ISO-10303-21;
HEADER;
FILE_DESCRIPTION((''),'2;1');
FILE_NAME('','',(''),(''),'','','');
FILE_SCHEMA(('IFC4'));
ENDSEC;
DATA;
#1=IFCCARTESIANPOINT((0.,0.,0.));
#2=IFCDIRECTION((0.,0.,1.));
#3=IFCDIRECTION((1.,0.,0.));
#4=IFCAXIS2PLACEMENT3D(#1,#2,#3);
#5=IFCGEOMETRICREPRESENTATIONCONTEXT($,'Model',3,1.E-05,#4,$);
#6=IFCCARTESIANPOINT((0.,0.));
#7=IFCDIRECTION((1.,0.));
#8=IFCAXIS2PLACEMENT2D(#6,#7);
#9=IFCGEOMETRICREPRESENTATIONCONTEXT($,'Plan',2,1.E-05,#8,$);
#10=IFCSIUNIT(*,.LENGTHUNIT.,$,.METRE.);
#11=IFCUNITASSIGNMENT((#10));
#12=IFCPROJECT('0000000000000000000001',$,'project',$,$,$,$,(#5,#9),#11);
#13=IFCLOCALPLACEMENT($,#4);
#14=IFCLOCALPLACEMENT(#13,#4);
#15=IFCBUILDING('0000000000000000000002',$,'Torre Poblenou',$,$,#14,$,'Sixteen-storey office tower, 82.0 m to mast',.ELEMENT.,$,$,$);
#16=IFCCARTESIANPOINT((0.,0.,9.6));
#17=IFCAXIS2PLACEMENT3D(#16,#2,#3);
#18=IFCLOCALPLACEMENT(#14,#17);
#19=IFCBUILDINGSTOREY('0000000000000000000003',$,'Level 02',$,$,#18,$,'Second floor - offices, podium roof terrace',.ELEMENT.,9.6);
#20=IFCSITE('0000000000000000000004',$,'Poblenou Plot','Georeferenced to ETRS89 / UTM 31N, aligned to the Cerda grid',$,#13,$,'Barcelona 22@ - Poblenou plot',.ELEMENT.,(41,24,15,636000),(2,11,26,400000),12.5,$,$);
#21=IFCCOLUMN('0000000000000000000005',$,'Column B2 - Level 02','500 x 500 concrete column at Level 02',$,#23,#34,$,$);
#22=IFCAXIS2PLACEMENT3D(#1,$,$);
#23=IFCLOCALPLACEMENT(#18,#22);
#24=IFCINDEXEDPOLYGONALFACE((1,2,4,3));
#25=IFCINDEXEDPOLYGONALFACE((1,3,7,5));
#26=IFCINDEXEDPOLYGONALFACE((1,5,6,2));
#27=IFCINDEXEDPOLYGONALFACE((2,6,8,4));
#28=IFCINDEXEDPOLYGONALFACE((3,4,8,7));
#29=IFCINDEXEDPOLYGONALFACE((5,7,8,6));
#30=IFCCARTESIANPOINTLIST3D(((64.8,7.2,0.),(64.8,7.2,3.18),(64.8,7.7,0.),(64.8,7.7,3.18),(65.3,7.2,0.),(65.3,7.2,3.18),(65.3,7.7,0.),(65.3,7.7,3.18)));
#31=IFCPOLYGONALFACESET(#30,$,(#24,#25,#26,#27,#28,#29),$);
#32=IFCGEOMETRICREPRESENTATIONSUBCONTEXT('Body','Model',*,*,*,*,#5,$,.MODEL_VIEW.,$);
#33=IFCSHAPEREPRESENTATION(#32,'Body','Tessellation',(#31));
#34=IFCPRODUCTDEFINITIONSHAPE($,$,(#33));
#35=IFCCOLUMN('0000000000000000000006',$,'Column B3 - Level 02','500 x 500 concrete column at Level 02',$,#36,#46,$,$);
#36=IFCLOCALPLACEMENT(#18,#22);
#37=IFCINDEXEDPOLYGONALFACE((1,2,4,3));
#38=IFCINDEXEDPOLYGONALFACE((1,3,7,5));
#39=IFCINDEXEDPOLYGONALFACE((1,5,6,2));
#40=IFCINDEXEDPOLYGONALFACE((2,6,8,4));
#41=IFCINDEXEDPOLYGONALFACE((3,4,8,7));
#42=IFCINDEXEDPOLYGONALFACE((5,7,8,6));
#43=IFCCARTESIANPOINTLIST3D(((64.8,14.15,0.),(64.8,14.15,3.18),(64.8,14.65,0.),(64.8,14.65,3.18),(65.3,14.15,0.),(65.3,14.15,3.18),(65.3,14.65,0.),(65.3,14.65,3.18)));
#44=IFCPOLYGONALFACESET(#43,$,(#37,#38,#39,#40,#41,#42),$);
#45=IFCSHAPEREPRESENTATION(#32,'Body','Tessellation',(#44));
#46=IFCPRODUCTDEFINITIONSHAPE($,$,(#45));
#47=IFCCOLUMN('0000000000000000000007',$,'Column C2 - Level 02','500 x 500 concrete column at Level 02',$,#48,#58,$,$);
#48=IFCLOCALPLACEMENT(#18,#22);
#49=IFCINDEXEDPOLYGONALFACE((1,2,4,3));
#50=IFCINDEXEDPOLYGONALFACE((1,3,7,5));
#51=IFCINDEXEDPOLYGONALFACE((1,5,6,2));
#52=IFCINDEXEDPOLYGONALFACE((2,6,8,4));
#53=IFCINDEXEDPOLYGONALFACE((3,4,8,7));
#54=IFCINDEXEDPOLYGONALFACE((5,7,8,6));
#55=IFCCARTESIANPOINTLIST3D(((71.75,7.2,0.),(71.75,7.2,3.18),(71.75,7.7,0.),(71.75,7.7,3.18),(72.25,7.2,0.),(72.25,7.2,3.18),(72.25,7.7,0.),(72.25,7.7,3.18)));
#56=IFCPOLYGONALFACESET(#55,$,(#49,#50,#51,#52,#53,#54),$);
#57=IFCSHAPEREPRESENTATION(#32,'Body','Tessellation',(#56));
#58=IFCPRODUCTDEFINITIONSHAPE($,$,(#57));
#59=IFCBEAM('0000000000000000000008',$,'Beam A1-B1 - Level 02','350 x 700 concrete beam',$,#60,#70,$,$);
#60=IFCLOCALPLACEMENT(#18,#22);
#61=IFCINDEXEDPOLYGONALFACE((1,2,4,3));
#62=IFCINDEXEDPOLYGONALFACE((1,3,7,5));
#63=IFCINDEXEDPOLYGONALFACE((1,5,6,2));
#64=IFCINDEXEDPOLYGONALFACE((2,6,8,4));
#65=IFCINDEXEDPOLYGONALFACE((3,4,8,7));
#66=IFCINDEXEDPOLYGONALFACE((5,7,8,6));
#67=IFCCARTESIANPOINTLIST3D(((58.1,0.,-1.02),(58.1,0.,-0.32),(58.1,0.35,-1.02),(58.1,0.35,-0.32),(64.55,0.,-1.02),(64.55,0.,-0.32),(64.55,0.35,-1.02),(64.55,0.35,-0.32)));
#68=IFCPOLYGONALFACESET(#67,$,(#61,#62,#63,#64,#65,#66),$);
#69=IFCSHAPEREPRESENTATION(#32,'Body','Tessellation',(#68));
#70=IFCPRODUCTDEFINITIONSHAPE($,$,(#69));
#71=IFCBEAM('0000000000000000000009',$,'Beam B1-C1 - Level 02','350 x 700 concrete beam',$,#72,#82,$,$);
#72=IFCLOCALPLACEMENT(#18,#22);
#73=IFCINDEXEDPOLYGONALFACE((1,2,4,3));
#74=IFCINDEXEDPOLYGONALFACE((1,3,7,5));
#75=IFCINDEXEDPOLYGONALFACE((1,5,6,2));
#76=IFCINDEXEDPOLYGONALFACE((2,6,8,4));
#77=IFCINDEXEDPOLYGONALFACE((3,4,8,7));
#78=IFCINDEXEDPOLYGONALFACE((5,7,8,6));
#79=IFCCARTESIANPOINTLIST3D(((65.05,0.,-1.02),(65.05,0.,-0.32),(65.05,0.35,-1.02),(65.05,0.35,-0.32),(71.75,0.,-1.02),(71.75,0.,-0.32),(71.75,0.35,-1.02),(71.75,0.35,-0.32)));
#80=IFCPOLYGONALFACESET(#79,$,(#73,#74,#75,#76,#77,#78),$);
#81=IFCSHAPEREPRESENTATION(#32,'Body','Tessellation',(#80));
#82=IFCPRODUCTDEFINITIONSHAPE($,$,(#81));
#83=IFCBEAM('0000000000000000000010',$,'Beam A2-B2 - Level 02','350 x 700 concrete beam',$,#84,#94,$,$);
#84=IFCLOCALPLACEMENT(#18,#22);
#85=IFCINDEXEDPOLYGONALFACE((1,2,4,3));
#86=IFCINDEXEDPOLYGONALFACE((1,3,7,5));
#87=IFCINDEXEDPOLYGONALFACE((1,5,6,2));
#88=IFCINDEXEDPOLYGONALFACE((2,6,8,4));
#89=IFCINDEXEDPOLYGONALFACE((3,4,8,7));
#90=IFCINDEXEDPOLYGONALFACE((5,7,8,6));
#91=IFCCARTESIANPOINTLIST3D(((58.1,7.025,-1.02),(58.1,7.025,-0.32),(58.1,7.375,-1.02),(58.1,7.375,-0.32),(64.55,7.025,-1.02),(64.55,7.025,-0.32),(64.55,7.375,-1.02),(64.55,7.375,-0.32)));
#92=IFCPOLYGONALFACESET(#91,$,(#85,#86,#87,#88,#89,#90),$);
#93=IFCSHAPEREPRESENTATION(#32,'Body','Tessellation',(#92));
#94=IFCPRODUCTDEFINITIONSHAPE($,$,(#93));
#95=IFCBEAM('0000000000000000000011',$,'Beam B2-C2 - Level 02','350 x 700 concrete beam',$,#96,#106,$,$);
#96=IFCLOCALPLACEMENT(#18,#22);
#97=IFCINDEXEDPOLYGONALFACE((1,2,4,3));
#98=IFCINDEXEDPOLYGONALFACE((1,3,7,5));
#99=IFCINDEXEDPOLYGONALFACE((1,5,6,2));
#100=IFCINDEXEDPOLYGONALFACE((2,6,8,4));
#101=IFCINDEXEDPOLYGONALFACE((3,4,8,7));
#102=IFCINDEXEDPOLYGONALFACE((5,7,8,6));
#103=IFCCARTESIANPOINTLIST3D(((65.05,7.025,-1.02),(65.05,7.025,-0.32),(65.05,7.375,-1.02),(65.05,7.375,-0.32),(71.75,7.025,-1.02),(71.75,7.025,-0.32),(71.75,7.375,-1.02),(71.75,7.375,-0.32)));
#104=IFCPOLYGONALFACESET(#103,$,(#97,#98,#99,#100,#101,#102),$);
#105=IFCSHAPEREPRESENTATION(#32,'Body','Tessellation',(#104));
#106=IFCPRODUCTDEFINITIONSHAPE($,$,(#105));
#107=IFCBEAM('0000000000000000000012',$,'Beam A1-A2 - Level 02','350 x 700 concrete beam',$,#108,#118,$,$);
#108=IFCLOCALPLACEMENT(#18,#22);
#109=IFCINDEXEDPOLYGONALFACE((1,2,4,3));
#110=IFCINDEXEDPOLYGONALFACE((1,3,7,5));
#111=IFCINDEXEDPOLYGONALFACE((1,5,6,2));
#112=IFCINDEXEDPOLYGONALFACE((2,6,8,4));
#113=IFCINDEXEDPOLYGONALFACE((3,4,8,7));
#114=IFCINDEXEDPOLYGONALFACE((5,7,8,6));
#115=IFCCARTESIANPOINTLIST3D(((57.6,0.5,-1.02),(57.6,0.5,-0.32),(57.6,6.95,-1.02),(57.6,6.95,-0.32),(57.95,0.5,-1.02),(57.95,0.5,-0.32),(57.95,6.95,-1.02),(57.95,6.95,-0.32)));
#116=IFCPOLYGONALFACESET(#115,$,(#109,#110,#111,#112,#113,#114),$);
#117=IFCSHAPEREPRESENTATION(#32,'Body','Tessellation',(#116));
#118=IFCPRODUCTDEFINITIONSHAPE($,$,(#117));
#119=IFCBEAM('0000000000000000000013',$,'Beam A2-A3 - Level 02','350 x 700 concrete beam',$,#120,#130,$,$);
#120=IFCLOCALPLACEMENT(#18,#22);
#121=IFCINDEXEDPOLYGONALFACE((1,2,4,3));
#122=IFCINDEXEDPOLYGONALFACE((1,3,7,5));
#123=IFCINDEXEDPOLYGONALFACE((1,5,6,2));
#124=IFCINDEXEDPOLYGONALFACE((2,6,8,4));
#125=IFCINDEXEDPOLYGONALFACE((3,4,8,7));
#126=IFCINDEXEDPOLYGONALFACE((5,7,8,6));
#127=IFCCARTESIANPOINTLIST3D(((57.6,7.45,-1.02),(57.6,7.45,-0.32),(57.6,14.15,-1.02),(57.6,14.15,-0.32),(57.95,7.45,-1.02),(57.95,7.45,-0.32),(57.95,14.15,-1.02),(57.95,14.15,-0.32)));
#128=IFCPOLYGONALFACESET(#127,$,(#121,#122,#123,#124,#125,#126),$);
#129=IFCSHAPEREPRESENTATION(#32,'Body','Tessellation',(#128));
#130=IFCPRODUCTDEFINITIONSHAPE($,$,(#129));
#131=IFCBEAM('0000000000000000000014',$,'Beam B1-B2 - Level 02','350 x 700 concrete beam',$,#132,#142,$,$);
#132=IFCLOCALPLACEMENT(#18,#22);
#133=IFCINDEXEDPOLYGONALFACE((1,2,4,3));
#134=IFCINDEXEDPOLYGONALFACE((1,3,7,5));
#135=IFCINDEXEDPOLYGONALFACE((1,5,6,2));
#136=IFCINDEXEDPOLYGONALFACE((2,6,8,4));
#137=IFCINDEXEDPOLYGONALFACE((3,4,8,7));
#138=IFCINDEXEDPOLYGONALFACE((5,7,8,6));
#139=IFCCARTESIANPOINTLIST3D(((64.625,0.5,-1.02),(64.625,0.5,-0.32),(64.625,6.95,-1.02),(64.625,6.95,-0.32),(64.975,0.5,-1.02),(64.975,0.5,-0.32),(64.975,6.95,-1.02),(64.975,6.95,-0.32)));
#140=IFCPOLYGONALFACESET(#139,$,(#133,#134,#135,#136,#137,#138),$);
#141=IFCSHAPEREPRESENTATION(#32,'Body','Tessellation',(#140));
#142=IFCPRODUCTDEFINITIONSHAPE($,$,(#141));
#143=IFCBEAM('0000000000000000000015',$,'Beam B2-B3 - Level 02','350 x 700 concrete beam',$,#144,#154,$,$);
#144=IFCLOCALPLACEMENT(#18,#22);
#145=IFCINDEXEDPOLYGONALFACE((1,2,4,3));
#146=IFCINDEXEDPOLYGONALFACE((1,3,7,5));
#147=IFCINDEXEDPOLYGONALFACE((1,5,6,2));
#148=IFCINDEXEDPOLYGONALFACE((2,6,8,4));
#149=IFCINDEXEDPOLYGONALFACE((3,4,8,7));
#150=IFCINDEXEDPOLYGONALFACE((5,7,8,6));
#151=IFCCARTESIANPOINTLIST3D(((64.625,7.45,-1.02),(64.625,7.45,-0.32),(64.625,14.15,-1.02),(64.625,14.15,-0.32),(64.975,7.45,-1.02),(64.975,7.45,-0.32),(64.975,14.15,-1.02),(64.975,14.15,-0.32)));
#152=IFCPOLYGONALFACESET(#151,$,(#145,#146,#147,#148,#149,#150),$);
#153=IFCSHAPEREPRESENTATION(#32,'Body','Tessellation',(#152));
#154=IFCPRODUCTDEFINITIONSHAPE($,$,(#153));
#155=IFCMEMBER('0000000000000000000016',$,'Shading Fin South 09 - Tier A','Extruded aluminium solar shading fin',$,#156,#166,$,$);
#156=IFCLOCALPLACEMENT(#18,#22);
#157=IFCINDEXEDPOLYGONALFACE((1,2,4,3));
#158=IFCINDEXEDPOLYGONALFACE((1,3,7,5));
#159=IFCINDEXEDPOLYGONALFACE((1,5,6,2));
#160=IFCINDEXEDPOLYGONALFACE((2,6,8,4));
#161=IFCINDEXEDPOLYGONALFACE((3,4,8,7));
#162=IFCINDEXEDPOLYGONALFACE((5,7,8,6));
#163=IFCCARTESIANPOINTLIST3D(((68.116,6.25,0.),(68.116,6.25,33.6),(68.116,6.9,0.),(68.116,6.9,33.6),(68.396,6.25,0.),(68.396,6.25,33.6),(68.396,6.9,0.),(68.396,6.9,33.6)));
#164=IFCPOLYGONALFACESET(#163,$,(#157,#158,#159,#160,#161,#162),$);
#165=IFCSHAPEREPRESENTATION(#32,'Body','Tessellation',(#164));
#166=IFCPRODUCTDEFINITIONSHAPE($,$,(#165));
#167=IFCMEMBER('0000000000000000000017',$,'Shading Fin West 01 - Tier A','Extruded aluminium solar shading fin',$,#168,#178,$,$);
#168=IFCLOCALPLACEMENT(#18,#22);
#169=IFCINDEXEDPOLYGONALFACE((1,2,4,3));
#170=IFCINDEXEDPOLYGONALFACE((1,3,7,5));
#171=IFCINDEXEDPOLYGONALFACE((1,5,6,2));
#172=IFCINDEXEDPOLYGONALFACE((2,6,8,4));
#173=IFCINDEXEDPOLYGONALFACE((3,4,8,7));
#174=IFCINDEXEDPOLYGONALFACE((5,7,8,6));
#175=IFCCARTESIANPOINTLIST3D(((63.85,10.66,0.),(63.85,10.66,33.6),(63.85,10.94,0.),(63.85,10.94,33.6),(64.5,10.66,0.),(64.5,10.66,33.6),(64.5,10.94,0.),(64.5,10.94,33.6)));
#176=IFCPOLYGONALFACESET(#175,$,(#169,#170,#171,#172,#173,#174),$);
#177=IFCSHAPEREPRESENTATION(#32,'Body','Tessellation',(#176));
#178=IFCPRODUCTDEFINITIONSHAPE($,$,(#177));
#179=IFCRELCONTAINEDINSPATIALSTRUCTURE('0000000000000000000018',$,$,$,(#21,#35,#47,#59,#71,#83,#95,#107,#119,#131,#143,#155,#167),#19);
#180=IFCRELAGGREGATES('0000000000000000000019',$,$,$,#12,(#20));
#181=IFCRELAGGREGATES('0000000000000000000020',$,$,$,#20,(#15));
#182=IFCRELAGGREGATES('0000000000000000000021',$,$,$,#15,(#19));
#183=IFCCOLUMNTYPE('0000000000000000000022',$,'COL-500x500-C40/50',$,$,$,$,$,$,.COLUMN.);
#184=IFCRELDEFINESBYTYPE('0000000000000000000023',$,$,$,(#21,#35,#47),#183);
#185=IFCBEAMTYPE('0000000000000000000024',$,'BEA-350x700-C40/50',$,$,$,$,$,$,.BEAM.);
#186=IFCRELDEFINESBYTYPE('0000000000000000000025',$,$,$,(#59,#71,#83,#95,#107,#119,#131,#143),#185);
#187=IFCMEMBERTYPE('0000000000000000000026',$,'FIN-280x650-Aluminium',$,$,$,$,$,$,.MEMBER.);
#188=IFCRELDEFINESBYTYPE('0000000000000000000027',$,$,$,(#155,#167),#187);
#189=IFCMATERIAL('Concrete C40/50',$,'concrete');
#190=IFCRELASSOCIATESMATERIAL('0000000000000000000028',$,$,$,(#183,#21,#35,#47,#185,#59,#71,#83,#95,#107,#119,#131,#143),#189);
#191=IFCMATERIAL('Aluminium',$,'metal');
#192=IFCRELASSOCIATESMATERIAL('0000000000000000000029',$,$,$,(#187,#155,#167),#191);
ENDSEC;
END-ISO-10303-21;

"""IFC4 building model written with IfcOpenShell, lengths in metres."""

from ifc_helpers import new_model, si_unit, frame, origin_with_axes, origin_2d_with_axis, place, context, subcontext, project, spatial, line, indexed_curve, rectangle, outline, extrude, material, material_profile, profile_set, profile_usage, type_object, element, save


model = new_model("IFC4")

# Units and contexts
model_context = context("Model", 3, precision=1e-05, world=origin_with_axes())
plan_context = context("Plan", 2, precision=1e-05, world=origin_2d_with_axis())
body_context = subcontext(model_context, "Body", "Model", "MODEL_VIEW")
ifc_project = project(units=[si_unit("LENGTHUNIT", "METRE")], contexts=[model_context, plan_context])

# Site, building, storey
site_placement = place(None, origin_with_axes())
site = spatial("IfcSite", under=ifc_project, at=site_placement, Name="Poblenou Plot", Description="Georeferenced to ETRS89 / UTM 31N, aligned to the Cerda grid", LongName="Barcelona 22@ - Poblenou plot", CompositionType="ELEMENT", RefLatitude=(41, 24, 15, 636000), RefLongitude=(2, 11, 26, 400000), RefElevation=12.5)
building_placement = place(site_placement, origin_with_axes())
building = spatial("IfcBuilding", under=site, at=building_placement, Name="Torre Poblenou", LongName="Sixteen-storey office tower, 82.0 m to mast", CompositionType="ELEMENT")
storey_placement = place(building_placement, frame((0.0, 0.0, 9.6), z_axis=(0.0, 0.0, 1.0), x_axis=(1.0, 0.0, 0.0)))
storey = spatial("IfcBuildingStorey", under=building, at=storey_placement, Name="Level 02", LongName="Second floor - offices, podium roof terrace", CompositionType="ELEMENT", Elevation=9.6)

# Columns
ifc_material_1 = material(Name="Concrete C40/50", Category="concrete")
ifc_material_profile_1 = material_profile(ifc_material_1, rectangle(XDim=0.5, YDim=0.5))
ifc_profile_set_1 = profile_set([ifc_material_profile_1], Name="COL-500x500-C40/50")
ifc_profile_usage_1 = profile_usage(ifc_profile_set_1)
column_type = type_object("IfcColumnType", Name="COL-500x500-C40/50", PredefinedType="COLUMN", material=ifc_profile_set_1)
column_1_placement = place(storey_placement, frame((64.8, 7.2, 0.0), z_axis=(0.0, 0.0, 1.0), x_axis=(1.0, 0.0, 0.0)))
element("IfcColumn", 1, at=column_1_placement, inside=storey, type_object=column_type, material=ifc_profile_usage_1, Name="Column B2 - Level 02", Description="500 x 500 concrete column at Level 02", context=body_context, shape_type="SweptSolid", body=[
    extrude(outline(indexed_curve([(0.0, 0.0), (0.5, 0.0), (0.5, 0.5), (0.0, 0.5)], segments=[line(1, 2, 3, 4, 1)])), origin_with_axes(), (0.0, 0.0, 1.0), 3.18),
])
ifc_profile_usage_2 = profile_usage(ifc_profile_set_1)
column_2_placement = place(storey_placement, frame((64.8, 14.15, 0.0), z_axis=(0.0, 0.0, 1.0), x_axis=(1.0, 0.0, 0.0)))
element("IfcColumn", 2, at=column_2_placement, inside=storey, type_object=column_type, material=ifc_profile_usage_2, Name="Column B3 - Level 02", Description="500 x 500 concrete column at Level 02", context=body_context, shape_type="SweptSolid", body=[
    extrude(outline(indexed_curve([(0.0, 0.0), (0.5, 0.0), (0.5, 0.5), (0.0, 0.5)], segments=[line(1, 2, 3, 4, 1)])), origin_with_axes(), (0.0, 0.0, 1.0), 3.18),
])
ifc_profile_usage_3 = profile_usage(ifc_profile_set_1)
column_3_placement = place(storey_placement, frame((71.75, 7.2, 0.0), z_axis=(0.0, 0.0, 1.0), x_axis=(1.0, 0.0, 0.0)))
element("IfcColumn", 3, at=column_3_placement, inside=storey, type_object=column_type, material=ifc_profile_usage_3, Name="Column C2 - Level 02", Description="500 x 500 concrete column at Level 02", context=body_context, shape_type="SweptSolid", body=[
    extrude(outline(indexed_curve([(0.0, 0.0), (0.5, 0.0), (0.5, 0.5), (0.0, 0.5)], segments=[line(1, 2, 3, 4, 1)])), origin_with_axes(), (0.0, 0.0, 1.0), 3.18),
])

# Beams
ifc_material_profile_2 = material_profile(ifc_material_1, rectangle(XDim=0.35, YDim=0.7))
ifc_profile_set_2 = profile_set([ifc_material_profile_2], Name="BEA-350x700-C40/50")
ifc_profile_usage_4 = profile_usage(ifc_profile_set_2)
beam_type = type_object("IfcBeamType", Name="BEA-350x700-C40/50", PredefinedType="BEAM", material=ifc_profile_set_2)
beam_1_placement = place(storey_placement, frame((58.1, 0.0, -1.02), z_axis=(0.0, 0.0, 1.0), x_axis=(1.0, 0.0, 0.0)))
element("IfcBeam", 4, at=beam_1_placement, inside=storey, type_object=beam_type, material=ifc_profile_usage_4, Name="Beam A1-B1 - Level 02", Description="350 x 700 concrete beam", context=body_context, shape_type="SweptSolid", body=[
    extrude(outline(indexed_curve([(0.0, 0.0), (6.45, 0.0), (6.45, 0.35), (0.0, 0.35)], segments=[line(1, 2, 3, 4, 1)])), origin_with_axes(), (0.0, 0.0, 1.0), 0.7),
])
ifc_profile_usage_5 = profile_usage(ifc_profile_set_2)
beam_2_placement = place(storey_placement, frame((65.05, 0.0, -1.02), z_axis=(0.0, 0.0, 1.0), x_axis=(1.0, 0.0, 0.0)))
element("IfcBeam", 5, at=beam_2_placement, inside=storey, type_object=beam_type, material=ifc_profile_usage_5, Name="Beam B1-C1 - Level 02", Description="350 x 700 concrete beam", context=body_context, shape_type="SweptSolid", body=[
    extrude(outline(indexed_curve([(0.0, 0.0), (6.7, 0.0), (6.7, 0.35), (0.0, 0.35)], segments=[line(1, 2, 3, 4, 1)])), origin_with_axes(), (0.0, 0.0, 1.0), 0.7),
])
ifc_profile_usage_6 = profile_usage(ifc_profile_set_2)
beam_3_placement = place(storey_placement, frame((58.1, 7.025, -1.02), z_axis=(0.0, 0.0, 1.0), x_axis=(1.0, 0.0, 0.0)))
element("IfcBeam", 6, at=beam_3_placement, inside=storey, type_object=beam_type, material=ifc_profile_usage_6, Name="Beam A2-B2 - Level 02", Description="350 x 700 concrete beam", context=body_context, shape_type="SweptSolid", body=[
    extrude(outline(indexed_curve([(0.0, 0.0), (6.45, 0.0), (6.45, 0.35), (0.0, 0.35)], segments=[line(1, 2, 3, 4, 1)])), origin_with_axes(), (0.0, 0.0, 1.0), 0.7),
])
ifc_profile_usage_7 = profile_usage(ifc_profile_set_2)
beam_4_placement = place(storey_placement, frame((65.05, 7.025, -1.02), z_axis=(0.0, 0.0, 1.0), x_axis=(1.0, 0.0, 0.0)))
element("IfcBeam", 7, at=beam_4_placement, inside=storey, type_object=beam_type, material=ifc_profile_usage_7, Name="Beam B2-C2 - Level 02", Description="350 x 700 concrete beam", context=body_context, shape_type="SweptSolid", body=[
    extrude(outline(indexed_curve([(0.0, 0.0), (6.7, 0.0), (6.7, 0.35), (0.0, 0.35)], segments=[line(1, 2, 3, 4, 1)])), origin_with_axes(), (0.0, 0.0, 1.0), 0.7),
])
ifc_profile_usage_8 = profile_usage(ifc_profile_set_2)
beam_5_placement = place(storey_placement, frame((57.95, 0.5, -1.02), z_axis=(0.0, 0.0, 1.0), x_axis=(0.0, 1.0, 0.0)))
element("IfcBeam", 8, at=beam_5_placement, inside=storey, type_object=beam_type, material=ifc_profile_usage_8, Name="Beam A1-A2 - Level 02", Description="350 x 700 concrete beam", context=body_context, shape_type="SweptSolid", body=[
    extrude(outline(indexed_curve([(0.0, 0.0), (6.45, 0.0), (6.45, 0.35), (0.0, 0.35)], segments=[line(1, 2, 3, 4, 1)])), origin_with_axes(), (0.0, 0.0, 1.0), 0.7),
])
ifc_profile_usage_9 = profile_usage(ifc_profile_set_2)
beam_6_placement = place(storey_placement, frame((57.95, 7.45, -1.02), z_axis=(0.0, 0.0, 1.0), x_axis=(0.0, 1.0, 0.0)))
element("IfcBeam", 9, at=beam_6_placement, inside=storey, type_object=beam_type, material=ifc_profile_usage_9, Name="Beam A2-A3 - Level 02", Description="350 x 700 concrete beam", context=body_context, shape_type="SweptSolid", body=[
    extrude(outline(indexed_curve([(0.0, 0.0), (6.7, 0.0), (6.7, 0.35), (0.0, 0.35)], segments=[line(1, 2, 3, 4, 1)])), origin_with_axes(), (0.0, 0.0, 1.0), 0.7),
])
ifc_profile_usage_10 = profile_usage(ifc_profile_set_2)
beam_7_placement = place(storey_placement, frame((64.975, 0.5, -1.02), z_axis=(0.0, 0.0, 1.0), x_axis=(0.0, 1.0, 0.0)))
element("IfcBeam", 10, at=beam_7_placement, inside=storey, type_object=beam_type, material=ifc_profile_usage_10, Name="Beam B1-B2 - Level 02", Description="350 x 700 concrete beam", context=body_context, shape_type="SweptSolid", body=[
    extrude(outline(indexed_curve([(0.0, 0.0), (6.45, 0.0), (6.45, 0.35), (0.0, 0.35)], segments=[line(1, 2, 3, 4, 1)])), origin_with_axes(), (0.0, 0.0, 1.0), 0.7),
])
ifc_profile_usage_11 = profile_usage(ifc_profile_set_2)
beam_8_placement = place(storey_placement, frame((64.975, 7.45, -1.02), z_axis=(0.0, 0.0, 1.0), x_axis=(0.0, 1.0, 0.0)))
element("IfcBeam", 11, at=beam_8_placement, inside=storey, type_object=beam_type, material=ifc_profile_usage_11, Name="Beam B2-B3 - Level 02", Description="350 x 700 concrete beam", context=body_context, shape_type="SweptSolid", body=[
    extrude(outline(indexed_curve([(0.0, 0.0), (6.7, 0.0), (6.7, 0.35), (0.0, 0.35)], segments=[line(1, 2, 3, 4, 1)])), origin_with_axes(), (0.0, 0.0, 1.0), 0.7),
])

# Members
ifc_material_2 = material(Name="Aluminium", Category="metal")
ifc_material_profile_3 = material_profile(ifc_material_2, rectangle(XDim=0.28, YDim=0.65))
ifc_profile_set_3 = profile_set([ifc_material_profile_3], Name="FIN-280x650-Aluminium")
ifc_profile_usage_12 = profile_usage(ifc_profile_set_3)
member_type = type_object("IfcMemberType", Name="FIN-280x650-Aluminium", PredefinedType="MEMBER", material=ifc_profile_set_3)
member_1_placement = place(storey_placement, frame((68.396, 6.9, 0.0), z_axis=(0.0, 0.0, 1.0), x_axis=(-1.0, 0.0, 0.0)))
element("IfcMember", 12, at=member_1_placement, inside=storey, type_object=member_type, material=ifc_profile_usage_12, Name="Shading Fin South 09 - Tier A", Description="Extruded aluminium solar shading fin", context=body_context, shape_type="SweptSolid", body=[
    extrude(outline(indexed_curve([(0.0, 0.0), (0.28, 0.0), (0.28, 0.65), (0.0, 0.65)], segments=[line(1, 2, 3, 4, 1)])), origin_with_axes(), (0.0, 0.0, 1.0), 33.6),
])
ifc_profile_usage_13 = profile_usage(ifc_profile_set_3)
member_2_placement = place(storey_placement, frame((64.5, 10.66, 0.0), z_axis=(0.0, 0.0, 1.0), x_axis=(0.0, 1.0, 0.0)))
element("IfcMember", 13, at=member_2_placement, inside=storey, type_object=member_type, material=ifc_profile_usage_13, Name="Shading Fin West 01 - Tier A", Description="Extruded aluminium solar shading fin", context=body_context, shape_type="SweptSolid", body=[
    extrude(outline(indexed_curve([(0.0, 0.0), (0.28, 0.0), (0.28, 0.65), (0.0, 0.65)], segments=[line(1, 2, 3, 4, 1)])), origin_with_axes(), (0.0, 0.0, 1.0), 33.6),
])

save(model, "model.ifc")
